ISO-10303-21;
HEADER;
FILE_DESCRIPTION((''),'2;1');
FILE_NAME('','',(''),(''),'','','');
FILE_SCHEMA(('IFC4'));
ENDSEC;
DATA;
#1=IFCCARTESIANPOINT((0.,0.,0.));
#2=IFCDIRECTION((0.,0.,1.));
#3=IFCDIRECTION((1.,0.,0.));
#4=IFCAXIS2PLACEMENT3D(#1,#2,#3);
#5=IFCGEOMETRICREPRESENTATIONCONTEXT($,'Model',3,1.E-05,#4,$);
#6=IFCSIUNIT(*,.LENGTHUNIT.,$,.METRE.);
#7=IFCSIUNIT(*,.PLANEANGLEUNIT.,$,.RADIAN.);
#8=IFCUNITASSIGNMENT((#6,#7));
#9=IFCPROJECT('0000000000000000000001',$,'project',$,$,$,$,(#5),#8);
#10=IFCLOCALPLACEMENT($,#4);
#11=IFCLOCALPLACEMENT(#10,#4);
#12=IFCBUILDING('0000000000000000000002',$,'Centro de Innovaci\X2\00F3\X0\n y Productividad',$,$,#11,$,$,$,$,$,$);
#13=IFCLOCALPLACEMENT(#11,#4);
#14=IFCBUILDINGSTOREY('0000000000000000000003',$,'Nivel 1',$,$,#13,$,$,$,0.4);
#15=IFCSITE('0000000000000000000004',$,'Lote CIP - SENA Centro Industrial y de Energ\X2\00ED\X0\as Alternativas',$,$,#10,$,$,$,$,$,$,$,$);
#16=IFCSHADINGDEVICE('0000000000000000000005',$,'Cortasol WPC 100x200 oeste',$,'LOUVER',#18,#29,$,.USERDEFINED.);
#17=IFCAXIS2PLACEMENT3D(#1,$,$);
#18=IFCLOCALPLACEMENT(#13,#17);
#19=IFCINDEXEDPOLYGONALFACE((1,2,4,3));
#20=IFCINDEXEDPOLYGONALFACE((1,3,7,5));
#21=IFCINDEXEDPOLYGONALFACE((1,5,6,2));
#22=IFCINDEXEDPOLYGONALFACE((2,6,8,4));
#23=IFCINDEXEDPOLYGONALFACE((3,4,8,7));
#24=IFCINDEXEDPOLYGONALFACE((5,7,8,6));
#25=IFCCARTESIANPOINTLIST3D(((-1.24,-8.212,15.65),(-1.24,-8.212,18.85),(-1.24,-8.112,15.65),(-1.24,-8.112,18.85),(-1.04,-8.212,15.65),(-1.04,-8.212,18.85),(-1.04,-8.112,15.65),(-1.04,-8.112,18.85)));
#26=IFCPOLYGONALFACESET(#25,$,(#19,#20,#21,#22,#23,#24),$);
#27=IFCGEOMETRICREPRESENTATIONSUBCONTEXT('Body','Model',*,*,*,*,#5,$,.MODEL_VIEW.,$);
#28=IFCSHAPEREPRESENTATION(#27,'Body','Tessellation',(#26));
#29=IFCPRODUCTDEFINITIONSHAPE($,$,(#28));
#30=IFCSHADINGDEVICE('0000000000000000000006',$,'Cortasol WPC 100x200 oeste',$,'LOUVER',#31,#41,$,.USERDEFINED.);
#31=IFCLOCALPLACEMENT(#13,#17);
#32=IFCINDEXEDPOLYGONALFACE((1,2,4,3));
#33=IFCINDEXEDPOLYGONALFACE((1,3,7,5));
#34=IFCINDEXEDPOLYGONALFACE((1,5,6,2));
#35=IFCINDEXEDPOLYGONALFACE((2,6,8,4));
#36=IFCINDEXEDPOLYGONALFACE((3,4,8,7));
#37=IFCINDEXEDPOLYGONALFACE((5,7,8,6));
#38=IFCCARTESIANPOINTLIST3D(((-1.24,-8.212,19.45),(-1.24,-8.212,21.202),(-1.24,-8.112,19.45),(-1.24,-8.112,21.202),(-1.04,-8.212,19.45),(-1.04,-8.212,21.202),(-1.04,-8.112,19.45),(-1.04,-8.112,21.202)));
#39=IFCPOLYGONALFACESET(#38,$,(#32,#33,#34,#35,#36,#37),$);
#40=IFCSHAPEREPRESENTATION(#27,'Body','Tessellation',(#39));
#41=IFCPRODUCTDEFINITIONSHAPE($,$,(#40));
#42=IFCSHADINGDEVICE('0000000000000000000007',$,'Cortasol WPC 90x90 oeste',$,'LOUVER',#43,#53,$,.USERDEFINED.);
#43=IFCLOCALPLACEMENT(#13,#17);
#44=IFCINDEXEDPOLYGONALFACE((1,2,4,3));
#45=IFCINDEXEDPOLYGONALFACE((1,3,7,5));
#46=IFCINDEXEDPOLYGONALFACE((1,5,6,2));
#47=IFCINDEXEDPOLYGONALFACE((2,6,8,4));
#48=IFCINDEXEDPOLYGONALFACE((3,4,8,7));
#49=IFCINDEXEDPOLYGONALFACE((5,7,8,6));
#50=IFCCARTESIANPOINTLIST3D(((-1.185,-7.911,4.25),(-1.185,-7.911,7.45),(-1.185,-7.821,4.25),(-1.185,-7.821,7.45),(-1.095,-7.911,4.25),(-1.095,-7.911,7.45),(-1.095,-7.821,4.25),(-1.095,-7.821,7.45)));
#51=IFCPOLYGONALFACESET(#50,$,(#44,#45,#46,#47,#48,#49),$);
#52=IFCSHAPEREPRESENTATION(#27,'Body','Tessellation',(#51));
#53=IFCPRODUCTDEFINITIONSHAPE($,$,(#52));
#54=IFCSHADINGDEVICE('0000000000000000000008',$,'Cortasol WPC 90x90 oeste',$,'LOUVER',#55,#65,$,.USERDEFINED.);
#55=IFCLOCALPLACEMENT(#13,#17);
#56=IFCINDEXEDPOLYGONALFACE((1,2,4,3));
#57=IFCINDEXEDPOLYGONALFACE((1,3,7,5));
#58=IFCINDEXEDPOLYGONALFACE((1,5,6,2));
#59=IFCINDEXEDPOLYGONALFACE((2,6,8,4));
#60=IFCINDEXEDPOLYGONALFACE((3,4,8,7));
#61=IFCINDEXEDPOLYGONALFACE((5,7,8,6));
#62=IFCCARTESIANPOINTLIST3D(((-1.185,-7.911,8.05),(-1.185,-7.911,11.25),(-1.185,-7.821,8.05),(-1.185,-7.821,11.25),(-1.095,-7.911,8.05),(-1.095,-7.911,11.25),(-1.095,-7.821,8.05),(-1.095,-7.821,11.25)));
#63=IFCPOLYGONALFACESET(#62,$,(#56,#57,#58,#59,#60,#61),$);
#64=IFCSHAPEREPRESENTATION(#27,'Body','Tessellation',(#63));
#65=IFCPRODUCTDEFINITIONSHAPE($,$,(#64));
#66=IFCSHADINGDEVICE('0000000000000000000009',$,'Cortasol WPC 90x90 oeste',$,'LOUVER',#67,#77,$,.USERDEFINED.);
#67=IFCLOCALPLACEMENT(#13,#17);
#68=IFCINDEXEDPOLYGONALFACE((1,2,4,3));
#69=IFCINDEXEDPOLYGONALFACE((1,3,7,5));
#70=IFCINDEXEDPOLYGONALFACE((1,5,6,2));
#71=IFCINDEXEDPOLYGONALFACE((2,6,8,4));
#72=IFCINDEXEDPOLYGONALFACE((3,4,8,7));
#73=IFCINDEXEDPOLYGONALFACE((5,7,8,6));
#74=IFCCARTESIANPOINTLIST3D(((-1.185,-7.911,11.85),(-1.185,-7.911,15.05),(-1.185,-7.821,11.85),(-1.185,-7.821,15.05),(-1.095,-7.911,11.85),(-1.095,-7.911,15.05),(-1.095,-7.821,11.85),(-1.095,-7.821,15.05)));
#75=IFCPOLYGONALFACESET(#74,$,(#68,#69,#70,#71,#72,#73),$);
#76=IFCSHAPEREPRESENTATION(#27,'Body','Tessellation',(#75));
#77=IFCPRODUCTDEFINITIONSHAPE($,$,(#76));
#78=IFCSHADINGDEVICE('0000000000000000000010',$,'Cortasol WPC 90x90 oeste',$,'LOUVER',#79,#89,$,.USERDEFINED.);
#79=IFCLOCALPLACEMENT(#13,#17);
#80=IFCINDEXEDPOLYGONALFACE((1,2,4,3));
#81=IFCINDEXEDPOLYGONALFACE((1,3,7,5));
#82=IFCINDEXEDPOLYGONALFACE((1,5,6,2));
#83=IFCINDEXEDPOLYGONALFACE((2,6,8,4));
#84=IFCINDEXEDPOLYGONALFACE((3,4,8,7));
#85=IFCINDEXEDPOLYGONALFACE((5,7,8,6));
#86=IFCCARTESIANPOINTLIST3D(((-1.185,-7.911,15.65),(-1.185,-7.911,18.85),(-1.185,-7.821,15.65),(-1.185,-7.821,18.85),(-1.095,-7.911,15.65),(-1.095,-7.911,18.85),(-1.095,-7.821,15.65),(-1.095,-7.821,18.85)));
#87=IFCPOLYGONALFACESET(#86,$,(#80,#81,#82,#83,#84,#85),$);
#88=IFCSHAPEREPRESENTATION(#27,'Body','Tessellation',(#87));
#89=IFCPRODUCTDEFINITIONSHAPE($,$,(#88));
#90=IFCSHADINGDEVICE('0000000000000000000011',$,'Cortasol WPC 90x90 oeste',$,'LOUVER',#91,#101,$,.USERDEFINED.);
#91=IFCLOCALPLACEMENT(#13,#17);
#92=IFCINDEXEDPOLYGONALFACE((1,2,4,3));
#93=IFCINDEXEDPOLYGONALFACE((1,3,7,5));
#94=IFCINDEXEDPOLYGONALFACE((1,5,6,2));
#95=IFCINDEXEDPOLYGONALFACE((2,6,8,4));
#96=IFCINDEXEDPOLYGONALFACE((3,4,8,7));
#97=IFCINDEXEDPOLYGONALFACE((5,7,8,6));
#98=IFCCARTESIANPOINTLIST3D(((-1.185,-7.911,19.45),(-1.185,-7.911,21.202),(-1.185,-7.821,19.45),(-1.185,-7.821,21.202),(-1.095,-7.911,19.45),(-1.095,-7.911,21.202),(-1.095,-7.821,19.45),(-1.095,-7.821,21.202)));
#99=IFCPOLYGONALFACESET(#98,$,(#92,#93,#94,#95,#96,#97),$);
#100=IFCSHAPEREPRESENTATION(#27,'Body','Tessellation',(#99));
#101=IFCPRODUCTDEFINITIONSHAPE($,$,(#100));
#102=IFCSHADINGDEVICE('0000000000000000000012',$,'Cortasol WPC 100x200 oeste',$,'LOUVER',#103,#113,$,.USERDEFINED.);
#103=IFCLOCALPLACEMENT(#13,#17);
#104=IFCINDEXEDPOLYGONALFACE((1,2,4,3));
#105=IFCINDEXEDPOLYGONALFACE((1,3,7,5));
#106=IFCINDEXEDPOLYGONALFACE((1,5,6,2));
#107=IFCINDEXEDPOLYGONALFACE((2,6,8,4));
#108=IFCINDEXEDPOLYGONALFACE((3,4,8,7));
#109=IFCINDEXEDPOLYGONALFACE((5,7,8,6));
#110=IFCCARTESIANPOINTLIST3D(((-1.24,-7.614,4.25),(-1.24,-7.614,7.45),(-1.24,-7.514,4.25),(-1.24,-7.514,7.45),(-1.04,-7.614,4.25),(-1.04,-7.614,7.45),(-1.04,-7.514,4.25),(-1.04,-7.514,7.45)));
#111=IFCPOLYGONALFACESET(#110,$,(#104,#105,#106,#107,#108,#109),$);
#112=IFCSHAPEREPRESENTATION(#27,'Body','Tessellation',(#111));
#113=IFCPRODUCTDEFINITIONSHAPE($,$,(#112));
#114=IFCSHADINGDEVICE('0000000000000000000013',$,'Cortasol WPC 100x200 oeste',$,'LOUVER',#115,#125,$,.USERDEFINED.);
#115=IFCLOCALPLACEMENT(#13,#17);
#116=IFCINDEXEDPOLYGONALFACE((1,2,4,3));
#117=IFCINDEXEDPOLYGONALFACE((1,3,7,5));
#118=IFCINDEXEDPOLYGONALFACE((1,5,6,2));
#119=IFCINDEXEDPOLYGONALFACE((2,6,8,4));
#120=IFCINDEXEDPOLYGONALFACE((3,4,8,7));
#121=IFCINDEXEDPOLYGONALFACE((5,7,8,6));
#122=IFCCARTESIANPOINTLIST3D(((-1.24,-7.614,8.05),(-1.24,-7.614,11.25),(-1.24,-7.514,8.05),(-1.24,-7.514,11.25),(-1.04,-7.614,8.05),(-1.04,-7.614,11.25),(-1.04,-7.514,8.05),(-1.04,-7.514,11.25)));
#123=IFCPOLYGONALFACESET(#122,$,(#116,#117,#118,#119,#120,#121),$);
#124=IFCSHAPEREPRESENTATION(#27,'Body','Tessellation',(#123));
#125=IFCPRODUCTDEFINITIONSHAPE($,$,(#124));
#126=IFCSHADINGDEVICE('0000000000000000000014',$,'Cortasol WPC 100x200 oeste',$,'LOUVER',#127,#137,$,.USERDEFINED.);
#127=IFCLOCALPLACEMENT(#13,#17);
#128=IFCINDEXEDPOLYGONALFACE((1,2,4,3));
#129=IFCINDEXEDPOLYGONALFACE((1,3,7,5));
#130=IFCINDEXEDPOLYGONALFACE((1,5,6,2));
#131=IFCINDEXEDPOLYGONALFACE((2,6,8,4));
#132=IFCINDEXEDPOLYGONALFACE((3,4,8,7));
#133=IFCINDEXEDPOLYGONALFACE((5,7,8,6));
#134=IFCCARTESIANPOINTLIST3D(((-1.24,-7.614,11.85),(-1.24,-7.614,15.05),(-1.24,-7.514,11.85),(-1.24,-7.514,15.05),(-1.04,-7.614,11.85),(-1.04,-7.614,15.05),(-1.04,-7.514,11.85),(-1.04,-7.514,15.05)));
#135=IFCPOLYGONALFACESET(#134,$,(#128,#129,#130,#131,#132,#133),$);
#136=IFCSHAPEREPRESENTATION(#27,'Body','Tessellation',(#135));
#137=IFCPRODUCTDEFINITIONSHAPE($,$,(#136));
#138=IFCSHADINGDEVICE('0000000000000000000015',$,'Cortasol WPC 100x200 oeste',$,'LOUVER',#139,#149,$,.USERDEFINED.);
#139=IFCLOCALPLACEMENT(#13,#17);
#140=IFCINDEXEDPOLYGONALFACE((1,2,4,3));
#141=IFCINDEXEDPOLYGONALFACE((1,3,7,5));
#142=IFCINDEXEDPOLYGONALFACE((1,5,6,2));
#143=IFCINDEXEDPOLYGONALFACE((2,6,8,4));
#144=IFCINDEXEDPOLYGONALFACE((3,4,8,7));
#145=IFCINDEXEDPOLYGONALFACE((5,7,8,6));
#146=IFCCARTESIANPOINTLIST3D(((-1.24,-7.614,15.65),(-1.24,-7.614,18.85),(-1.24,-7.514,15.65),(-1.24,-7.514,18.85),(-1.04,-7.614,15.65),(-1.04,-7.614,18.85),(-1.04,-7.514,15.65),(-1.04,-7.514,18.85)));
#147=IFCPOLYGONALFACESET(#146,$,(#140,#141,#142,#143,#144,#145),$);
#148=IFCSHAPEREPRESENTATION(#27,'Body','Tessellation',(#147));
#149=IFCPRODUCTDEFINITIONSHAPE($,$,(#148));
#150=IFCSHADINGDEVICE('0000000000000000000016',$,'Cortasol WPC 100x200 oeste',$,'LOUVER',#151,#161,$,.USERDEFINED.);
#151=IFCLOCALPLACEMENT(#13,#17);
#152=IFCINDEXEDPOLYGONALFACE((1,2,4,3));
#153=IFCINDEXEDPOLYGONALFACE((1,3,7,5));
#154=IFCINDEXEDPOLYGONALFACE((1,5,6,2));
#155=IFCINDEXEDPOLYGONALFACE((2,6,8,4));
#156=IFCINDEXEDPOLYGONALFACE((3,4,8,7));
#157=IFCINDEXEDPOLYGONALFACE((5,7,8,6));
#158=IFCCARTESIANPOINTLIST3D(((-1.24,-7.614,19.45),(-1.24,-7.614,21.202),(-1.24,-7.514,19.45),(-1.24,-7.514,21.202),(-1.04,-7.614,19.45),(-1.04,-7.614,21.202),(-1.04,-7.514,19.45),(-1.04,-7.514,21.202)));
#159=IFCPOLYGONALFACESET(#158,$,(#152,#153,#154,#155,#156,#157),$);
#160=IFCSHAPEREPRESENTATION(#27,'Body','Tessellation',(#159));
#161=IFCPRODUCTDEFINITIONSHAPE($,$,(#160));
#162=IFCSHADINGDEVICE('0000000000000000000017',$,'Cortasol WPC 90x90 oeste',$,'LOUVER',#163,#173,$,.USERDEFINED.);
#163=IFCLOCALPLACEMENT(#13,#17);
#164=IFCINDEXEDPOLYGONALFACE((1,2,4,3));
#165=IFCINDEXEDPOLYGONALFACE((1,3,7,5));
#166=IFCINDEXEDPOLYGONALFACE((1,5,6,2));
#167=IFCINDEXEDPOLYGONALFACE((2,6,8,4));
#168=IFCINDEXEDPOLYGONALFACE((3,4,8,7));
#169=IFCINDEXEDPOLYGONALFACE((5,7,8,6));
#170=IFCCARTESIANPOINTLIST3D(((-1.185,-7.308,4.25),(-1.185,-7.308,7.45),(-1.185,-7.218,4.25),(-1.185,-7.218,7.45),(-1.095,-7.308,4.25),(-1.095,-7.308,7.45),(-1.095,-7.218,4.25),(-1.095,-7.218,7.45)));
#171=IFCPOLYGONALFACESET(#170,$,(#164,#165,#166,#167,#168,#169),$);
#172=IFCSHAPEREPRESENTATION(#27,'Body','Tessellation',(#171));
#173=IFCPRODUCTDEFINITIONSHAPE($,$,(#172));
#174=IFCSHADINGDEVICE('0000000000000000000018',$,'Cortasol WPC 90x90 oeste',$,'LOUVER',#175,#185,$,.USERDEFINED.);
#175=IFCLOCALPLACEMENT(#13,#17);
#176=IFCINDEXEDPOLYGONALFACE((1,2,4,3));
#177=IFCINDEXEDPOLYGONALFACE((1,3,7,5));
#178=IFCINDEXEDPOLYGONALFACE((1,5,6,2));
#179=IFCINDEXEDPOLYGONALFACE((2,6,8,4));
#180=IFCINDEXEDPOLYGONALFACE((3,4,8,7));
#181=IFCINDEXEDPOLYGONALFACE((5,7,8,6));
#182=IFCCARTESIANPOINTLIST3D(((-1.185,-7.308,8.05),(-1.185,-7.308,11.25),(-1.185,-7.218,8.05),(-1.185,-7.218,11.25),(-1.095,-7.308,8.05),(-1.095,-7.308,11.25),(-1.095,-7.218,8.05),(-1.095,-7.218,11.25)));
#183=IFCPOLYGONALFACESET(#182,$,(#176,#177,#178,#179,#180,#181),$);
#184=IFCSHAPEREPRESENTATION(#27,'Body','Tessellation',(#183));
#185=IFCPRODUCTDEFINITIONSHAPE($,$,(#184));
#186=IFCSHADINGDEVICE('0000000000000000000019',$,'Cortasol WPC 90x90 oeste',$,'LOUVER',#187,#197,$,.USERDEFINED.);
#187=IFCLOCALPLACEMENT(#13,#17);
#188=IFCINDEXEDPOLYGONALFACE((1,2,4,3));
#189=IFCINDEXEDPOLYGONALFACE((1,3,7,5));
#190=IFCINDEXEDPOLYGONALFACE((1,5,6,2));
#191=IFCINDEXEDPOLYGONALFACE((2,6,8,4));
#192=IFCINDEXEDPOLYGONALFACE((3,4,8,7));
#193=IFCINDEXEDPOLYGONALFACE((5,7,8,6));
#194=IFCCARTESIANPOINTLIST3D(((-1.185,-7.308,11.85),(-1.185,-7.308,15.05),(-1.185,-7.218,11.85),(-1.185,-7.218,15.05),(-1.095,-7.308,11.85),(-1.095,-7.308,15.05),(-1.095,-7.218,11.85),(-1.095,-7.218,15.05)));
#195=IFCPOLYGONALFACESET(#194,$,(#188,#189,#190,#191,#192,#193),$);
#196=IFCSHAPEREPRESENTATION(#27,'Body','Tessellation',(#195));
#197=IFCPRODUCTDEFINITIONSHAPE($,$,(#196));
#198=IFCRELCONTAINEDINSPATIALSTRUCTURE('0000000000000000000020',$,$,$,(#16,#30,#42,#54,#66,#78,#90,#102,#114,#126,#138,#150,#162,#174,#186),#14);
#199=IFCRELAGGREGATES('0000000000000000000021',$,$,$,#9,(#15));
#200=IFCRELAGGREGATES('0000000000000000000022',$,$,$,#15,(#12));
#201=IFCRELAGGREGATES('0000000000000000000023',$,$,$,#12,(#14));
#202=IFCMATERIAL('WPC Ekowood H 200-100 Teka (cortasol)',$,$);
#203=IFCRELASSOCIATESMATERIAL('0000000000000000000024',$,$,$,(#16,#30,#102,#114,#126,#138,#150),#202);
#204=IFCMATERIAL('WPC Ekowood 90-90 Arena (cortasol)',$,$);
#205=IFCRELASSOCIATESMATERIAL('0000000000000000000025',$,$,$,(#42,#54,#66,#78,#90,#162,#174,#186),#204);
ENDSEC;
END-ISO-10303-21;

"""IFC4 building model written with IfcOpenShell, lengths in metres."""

from ifc_helpers import new_model, si_unit, frame, origin_with_axes, place, context, subcontext, project, spatial, polyline, outline, extrude, material, element, save


model = new_model("IFC4")

# Units and contexts
model_context = context("Model", 3, precision=1e-05, world=origin_with_axes())
body_context = subcontext(model_context, "Body", "Model", "MODEL_VIEW")
ifc_project = project(units=[si_unit("LENGTHUNIT", "METRE"), si_unit("PLANEANGLEUNIT", "RADIAN")], contexts=[model_context])

# Site, building, storey
site_placement = place(None, origin_with_axes())
site = spatial("IfcSite", under=ifc_project, at=site_placement, Name="Lote CIP - SENA Centro Industrial y de Energías Alternativas")
building_placement = place(site_placement, origin_with_axes())
building = spatial("IfcBuilding", under=site, at=building_placement, Name="Centro de Innovación y Productividad")
storey_placement = place(building_placement, origin_with_axes())
storey = spatial("IfcBuildingStorey", under=building, at=storey_placement, Name="Nivel 1", Elevation=0.4)

# Shading devices
ifc_material_1 = material(Name="WPC Ekowood H 200-100 Teka (cortasol)")
shading_device_1_placement = place(storey_placement, origin_with_axes())
element("IfcShadingDevice", 1, at=shading_device_1_placement, inside=storey, material=ifc_material_1, Name="Cortasol WPC 100x200 oeste", ObjectType="LOUVER", PredefinedType="USERDEFINED", context=body_context, shape_type="SweptSolid", body=[
    extrude(outline(polyline([(-1.04, -8.212), (-1.24, -8.212), (-1.24, -8.112), (-1.04, -8.112), (-1.04, -8.212)])), frame((0.0, 0.0, 15.65)), (0.0, 0.0, 1.0), 3.2),
])
shading_device_2_placement = place(storey_placement, origin_with_axes())
element("IfcShadingDevice", 2, at=shading_device_2_placement, inside=storey, material=ifc_material_1, Name="Cortasol WPC 100x200 oeste", ObjectType="LOUVER", PredefinedType="USERDEFINED", context=body_context, shape_type="SweptSolid", body=[
    extrude(outline(polyline([(-1.04, -8.212), (-1.24, -8.212), (-1.24, -8.112), (-1.04, -8.112), (-1.04, -8.212)])), frame((0.0, 0.0, 19.45)), (0.0, 0.0, 1.0), 1.752),
])
ifc_material_2 = material(Name="WPC Ekowood 90-90 Arena (cortasol)")
shading_device_3_placement = place(storey_placement, origin_with_axes())
element("IfcShadingDevice", 3, at=shading_device_3_placement, inside=storey, material=ifc_material_2, Name="Cortasol WPC 90x90 oeste", ObjectType="LOUVER", PredefinedType="USERDEFINED", context=body_context, shape_type="SweptSolid", body=[
    extrude(outline(polyline([(-1.095, -7.911), (-1.185, -7.911), (-1.185, -7.821), (-1.095, -7.821), (-1.095, -7.911)])), frame((0.0, 0.0, 4.25)), (0.0, 0.0, 1.0), 3.2),
])
shading_device_4_placement = place(storey_placement, origin_with_axes())
element("IfcShadingDevice", 4, at=shading_device_4_placement, inside=storey, material=ifc_material_2, Name="Cortasol WPC 90x90 oeste", ObjectType="LOUVER", PredefinedType="USERDEFINED", context=body_context, shape_type="SweptSolid", body=[
    extrude(outline(polyline([(-1.095, -7.911), (-1.185, -7.911), (-1.185, -7.821), (-1.095, -7.821), (-1.095, -7.911)])), frame((0.0, 0.0, 8.05)), (0.0, 0.0, 1.0), 3.2),
])
shading_device_5_placement = place(storey_placement, origin_with_axes())
element("IfcShadingDevice", 5, at=shading_device_5_placement, inside=storey, material=ifc_material_2, Name="Cortasol WPC 90x90 oeste", ObjectType="LOUVER", PredefinedType="USERDEFINED", context=body_context, shape_type="SweptSolid", body=[
    extrude(outline(polyline([(-1.095, -7.911), (-1.185, -7.911), (-1.185, -7.821), (-1.095, -7.821), (-1.095, -7.911)])), frame((0.0, 0.0, 11.85)), (0.0, 0.0, 1.0), 3.2),
])
shading_device_6_placement = place(storey_placement, origin_with_axes())
element("IfcShadingDevice", 6, at=shading_device_6_placement, inside=storey, material=ifc_material_2, Name="Cortasol WPC 90x90 oeste", ObjectType="LOUVER", PredefinedType="USERDEFINED", context=body_context, shape_type="SweptSolid", body=[
    extrude(outline(polyline([(-1.095, -7.911), (-1.185, -7.911), (-1.185, -7.821), (-1.095, -7.821), (-1.095, -7.911)])), frame((0.0, 0.0, 15.65)), (0.0, 0.0, 1.0), 3.2),
])
shading_device_7_placement = place(storey_placement, origin_with_axes())
element("IfcShadingDevice", 7, at=shading_device_7_placement, inside=storey, material=ifc_material_2, Name="Cortasol WPC 90x90 oeste", ObjectType="LOUVER", PredefinedType="USERDEFINED", context=body_context, shape_type="SweptSolid", body=[
    extrude(outline(polyline([(-1.095, -7.911), (-1.185, -7.911), (-1.185, -7.821), (-1.095, -7.821), (-1.095, -7.911)])), frame((0.0, 0.0, 19.45)), (0.0, 0.0, 1.0), 1.752),
])
shading_device_8_placement = place(storey_placement, origin_with_axes())
element("IfcShadingDevice", 8, at=shading_device_8_placement, inside=storey, material=ifc_material_1, Name="Cortasol WPC 100x200 oeste", ObjectType="LOUVER", PredefinedType="USERDEFINED", context=body_context, shape_type="SweptSolid", body=[
    extrude(outline(polyline([(-1.04, -7.614), (-1.24, -7.614), (-1.24, -7.514), (-1.04, -7.514), (-1.04, -7.614)])), frame((0.0, 0.0, 4.25)), (0.0, 0.0, 1.0), 3.2),
])
shading_device_9_placement = place(storey_placement, origin_with_axes())
element("IfcShadingDevice", 9, at=shading_device_9_placement, inside=storey, material=ifc_material_1, Name="Cortasol WPC 100x200 oeste", ObjectType="LOUVER", PredefinedType="USERDEFINED", context=body_context, shape_type="SweptSolid", body=[
    extrude(outline(polyline([(-1.04, -7.614), (-1.24, -7.614), (-1.24, -7.514), (-1.04, -7.514), (-1.04, -7.614)])), frame((0.0, 0.0, 8.05)), (0.0, 0.0, 1.0), 3.2),
])
shading_device_10_placement = place(storey_placement, origin_with_axes())
element("IfcShadingDevice", 10, at=shading_device_10_placement, inside=storey, material=ifc_material_1, Name="Cortasol WPC 100x200 oeste", ObjectType="LOUVER", PredefinedType="USERDEFINED", context=body_context, shape_type="SweptSolid", body=[
    extrude(outline(polyline([(-1.04, -7.614), (-1.24, -7.614), (-1.24, -7.514), (-1.04, -7.514), (-1.04, -7.614)])), frame((0.0, 0.0, 11.85)), (0.0, 0.0, 1.0), 3.2),
])
shading_device_11_placement = place(storey_placement, origin_with_axes())
element("IfcShadingDevice", 11, at=shading_device_11_placement, inside=storey, material=ifc_material_1, Name="Cortasol WPC 100x200 oeste", ObjectType="LOUVER", PredefinedType="USERDEFINED", context=body_context, shape_type="SweptSolid", body=[
    extrude(outline(polyline([(-1.04, -7.614), (-1.24, -7.614), (-1.24, -7.514), (-1.04, -7.514), (-1.04, -7.614)])), frame((0.0, 0.0, 15.65)), (0.0, 0.0, 1.0), 3.2),
])
shading_device_12_placement = place(storey_placement, origin_with_axes())
element("IfcShadingDevice", 12, at=shading_device_12_placement, inside=storey, material=ifc_material_1, Name="Cortasol WPC 100x200 oeste", ObjectType="LOUVER", PredefinedType="USERDEFINED", context=body_context, shape_type="SweptSolid", body=[
    extrude(outline(polyline([(-1.04, -7.614), (-1.24, -7.614), (-1.24, -7.514), (-1.04, -7.514), (-1.04, -7.614)])), frame((0.0, 0.0, 19.45)), (0.0, 0.0, 1.0), 1.752),
])
shading_device_13_placement = place(storey_placement, origin_with_axes())
element("IfcShadingDevice", 13, at=shading_device_13_placement, inside=storey, material=ifc_material_2, Name="Cortasol WPC 90x90 oeste", ObjectType="LOUVER", PredefinedType="USERDEFINED", context=body_context, shape_type="SweptSolid", body=[
    extrude(outline(polyline([(-1.095, -7.308), (-1.185, -7.308), (-1.185, -7.218), (-1.095, -7.218), (-1.095, -7.308)])), frame((0.0, 0.0, 4.25)), (0.0, 0.0, 1.0), 3.2),
])
shading_device_14_placement = place(storey_placement, origin_with_axes())
element("IfcShadingDevice", 14, at=shading_device_14_placement, inside=storey, material=ifc_material_2, Name="Cortasol WPC 90x90 oeste", ObjectType="LOUVER", PredefinedType="USERDEFINED", context=body_context, shape_type="SweptSolid", body=[
    extrude(outline(polyline([(-1.095, -7.308), (-1.185, -7.308), (-1.185, -7.218), (-1.095, -7.218), (-1.095, -7.308)])), frame((0.0, 0.0, 8.05)), (0.0, 0.0, 1.0), 3.2),
])
shading_device_15_placement = place(storey_placement, origin_with_axes())
element("IfcShadingDevice", 15, at=shading_device_15_placement, inside=storey, material=ifc_material_2, Name="Cortasol WPC 90x90 oeste", ObjectType="LOUVER", PredefinedType="USERDEFINED", context=body_context, shape_type="SweptSolid", body=[
    extrude(outline(polyline([(-1.095, -7.308), (-1.185, -7.308), (-1.185, -7.218), (-1.095, -7.218), (-1.095, -7.308)])), frame((0.0, 0.0, 11.85)), (0.0, 0.0, 1.0), 3.2),
])

save(model, "model.ifc")
